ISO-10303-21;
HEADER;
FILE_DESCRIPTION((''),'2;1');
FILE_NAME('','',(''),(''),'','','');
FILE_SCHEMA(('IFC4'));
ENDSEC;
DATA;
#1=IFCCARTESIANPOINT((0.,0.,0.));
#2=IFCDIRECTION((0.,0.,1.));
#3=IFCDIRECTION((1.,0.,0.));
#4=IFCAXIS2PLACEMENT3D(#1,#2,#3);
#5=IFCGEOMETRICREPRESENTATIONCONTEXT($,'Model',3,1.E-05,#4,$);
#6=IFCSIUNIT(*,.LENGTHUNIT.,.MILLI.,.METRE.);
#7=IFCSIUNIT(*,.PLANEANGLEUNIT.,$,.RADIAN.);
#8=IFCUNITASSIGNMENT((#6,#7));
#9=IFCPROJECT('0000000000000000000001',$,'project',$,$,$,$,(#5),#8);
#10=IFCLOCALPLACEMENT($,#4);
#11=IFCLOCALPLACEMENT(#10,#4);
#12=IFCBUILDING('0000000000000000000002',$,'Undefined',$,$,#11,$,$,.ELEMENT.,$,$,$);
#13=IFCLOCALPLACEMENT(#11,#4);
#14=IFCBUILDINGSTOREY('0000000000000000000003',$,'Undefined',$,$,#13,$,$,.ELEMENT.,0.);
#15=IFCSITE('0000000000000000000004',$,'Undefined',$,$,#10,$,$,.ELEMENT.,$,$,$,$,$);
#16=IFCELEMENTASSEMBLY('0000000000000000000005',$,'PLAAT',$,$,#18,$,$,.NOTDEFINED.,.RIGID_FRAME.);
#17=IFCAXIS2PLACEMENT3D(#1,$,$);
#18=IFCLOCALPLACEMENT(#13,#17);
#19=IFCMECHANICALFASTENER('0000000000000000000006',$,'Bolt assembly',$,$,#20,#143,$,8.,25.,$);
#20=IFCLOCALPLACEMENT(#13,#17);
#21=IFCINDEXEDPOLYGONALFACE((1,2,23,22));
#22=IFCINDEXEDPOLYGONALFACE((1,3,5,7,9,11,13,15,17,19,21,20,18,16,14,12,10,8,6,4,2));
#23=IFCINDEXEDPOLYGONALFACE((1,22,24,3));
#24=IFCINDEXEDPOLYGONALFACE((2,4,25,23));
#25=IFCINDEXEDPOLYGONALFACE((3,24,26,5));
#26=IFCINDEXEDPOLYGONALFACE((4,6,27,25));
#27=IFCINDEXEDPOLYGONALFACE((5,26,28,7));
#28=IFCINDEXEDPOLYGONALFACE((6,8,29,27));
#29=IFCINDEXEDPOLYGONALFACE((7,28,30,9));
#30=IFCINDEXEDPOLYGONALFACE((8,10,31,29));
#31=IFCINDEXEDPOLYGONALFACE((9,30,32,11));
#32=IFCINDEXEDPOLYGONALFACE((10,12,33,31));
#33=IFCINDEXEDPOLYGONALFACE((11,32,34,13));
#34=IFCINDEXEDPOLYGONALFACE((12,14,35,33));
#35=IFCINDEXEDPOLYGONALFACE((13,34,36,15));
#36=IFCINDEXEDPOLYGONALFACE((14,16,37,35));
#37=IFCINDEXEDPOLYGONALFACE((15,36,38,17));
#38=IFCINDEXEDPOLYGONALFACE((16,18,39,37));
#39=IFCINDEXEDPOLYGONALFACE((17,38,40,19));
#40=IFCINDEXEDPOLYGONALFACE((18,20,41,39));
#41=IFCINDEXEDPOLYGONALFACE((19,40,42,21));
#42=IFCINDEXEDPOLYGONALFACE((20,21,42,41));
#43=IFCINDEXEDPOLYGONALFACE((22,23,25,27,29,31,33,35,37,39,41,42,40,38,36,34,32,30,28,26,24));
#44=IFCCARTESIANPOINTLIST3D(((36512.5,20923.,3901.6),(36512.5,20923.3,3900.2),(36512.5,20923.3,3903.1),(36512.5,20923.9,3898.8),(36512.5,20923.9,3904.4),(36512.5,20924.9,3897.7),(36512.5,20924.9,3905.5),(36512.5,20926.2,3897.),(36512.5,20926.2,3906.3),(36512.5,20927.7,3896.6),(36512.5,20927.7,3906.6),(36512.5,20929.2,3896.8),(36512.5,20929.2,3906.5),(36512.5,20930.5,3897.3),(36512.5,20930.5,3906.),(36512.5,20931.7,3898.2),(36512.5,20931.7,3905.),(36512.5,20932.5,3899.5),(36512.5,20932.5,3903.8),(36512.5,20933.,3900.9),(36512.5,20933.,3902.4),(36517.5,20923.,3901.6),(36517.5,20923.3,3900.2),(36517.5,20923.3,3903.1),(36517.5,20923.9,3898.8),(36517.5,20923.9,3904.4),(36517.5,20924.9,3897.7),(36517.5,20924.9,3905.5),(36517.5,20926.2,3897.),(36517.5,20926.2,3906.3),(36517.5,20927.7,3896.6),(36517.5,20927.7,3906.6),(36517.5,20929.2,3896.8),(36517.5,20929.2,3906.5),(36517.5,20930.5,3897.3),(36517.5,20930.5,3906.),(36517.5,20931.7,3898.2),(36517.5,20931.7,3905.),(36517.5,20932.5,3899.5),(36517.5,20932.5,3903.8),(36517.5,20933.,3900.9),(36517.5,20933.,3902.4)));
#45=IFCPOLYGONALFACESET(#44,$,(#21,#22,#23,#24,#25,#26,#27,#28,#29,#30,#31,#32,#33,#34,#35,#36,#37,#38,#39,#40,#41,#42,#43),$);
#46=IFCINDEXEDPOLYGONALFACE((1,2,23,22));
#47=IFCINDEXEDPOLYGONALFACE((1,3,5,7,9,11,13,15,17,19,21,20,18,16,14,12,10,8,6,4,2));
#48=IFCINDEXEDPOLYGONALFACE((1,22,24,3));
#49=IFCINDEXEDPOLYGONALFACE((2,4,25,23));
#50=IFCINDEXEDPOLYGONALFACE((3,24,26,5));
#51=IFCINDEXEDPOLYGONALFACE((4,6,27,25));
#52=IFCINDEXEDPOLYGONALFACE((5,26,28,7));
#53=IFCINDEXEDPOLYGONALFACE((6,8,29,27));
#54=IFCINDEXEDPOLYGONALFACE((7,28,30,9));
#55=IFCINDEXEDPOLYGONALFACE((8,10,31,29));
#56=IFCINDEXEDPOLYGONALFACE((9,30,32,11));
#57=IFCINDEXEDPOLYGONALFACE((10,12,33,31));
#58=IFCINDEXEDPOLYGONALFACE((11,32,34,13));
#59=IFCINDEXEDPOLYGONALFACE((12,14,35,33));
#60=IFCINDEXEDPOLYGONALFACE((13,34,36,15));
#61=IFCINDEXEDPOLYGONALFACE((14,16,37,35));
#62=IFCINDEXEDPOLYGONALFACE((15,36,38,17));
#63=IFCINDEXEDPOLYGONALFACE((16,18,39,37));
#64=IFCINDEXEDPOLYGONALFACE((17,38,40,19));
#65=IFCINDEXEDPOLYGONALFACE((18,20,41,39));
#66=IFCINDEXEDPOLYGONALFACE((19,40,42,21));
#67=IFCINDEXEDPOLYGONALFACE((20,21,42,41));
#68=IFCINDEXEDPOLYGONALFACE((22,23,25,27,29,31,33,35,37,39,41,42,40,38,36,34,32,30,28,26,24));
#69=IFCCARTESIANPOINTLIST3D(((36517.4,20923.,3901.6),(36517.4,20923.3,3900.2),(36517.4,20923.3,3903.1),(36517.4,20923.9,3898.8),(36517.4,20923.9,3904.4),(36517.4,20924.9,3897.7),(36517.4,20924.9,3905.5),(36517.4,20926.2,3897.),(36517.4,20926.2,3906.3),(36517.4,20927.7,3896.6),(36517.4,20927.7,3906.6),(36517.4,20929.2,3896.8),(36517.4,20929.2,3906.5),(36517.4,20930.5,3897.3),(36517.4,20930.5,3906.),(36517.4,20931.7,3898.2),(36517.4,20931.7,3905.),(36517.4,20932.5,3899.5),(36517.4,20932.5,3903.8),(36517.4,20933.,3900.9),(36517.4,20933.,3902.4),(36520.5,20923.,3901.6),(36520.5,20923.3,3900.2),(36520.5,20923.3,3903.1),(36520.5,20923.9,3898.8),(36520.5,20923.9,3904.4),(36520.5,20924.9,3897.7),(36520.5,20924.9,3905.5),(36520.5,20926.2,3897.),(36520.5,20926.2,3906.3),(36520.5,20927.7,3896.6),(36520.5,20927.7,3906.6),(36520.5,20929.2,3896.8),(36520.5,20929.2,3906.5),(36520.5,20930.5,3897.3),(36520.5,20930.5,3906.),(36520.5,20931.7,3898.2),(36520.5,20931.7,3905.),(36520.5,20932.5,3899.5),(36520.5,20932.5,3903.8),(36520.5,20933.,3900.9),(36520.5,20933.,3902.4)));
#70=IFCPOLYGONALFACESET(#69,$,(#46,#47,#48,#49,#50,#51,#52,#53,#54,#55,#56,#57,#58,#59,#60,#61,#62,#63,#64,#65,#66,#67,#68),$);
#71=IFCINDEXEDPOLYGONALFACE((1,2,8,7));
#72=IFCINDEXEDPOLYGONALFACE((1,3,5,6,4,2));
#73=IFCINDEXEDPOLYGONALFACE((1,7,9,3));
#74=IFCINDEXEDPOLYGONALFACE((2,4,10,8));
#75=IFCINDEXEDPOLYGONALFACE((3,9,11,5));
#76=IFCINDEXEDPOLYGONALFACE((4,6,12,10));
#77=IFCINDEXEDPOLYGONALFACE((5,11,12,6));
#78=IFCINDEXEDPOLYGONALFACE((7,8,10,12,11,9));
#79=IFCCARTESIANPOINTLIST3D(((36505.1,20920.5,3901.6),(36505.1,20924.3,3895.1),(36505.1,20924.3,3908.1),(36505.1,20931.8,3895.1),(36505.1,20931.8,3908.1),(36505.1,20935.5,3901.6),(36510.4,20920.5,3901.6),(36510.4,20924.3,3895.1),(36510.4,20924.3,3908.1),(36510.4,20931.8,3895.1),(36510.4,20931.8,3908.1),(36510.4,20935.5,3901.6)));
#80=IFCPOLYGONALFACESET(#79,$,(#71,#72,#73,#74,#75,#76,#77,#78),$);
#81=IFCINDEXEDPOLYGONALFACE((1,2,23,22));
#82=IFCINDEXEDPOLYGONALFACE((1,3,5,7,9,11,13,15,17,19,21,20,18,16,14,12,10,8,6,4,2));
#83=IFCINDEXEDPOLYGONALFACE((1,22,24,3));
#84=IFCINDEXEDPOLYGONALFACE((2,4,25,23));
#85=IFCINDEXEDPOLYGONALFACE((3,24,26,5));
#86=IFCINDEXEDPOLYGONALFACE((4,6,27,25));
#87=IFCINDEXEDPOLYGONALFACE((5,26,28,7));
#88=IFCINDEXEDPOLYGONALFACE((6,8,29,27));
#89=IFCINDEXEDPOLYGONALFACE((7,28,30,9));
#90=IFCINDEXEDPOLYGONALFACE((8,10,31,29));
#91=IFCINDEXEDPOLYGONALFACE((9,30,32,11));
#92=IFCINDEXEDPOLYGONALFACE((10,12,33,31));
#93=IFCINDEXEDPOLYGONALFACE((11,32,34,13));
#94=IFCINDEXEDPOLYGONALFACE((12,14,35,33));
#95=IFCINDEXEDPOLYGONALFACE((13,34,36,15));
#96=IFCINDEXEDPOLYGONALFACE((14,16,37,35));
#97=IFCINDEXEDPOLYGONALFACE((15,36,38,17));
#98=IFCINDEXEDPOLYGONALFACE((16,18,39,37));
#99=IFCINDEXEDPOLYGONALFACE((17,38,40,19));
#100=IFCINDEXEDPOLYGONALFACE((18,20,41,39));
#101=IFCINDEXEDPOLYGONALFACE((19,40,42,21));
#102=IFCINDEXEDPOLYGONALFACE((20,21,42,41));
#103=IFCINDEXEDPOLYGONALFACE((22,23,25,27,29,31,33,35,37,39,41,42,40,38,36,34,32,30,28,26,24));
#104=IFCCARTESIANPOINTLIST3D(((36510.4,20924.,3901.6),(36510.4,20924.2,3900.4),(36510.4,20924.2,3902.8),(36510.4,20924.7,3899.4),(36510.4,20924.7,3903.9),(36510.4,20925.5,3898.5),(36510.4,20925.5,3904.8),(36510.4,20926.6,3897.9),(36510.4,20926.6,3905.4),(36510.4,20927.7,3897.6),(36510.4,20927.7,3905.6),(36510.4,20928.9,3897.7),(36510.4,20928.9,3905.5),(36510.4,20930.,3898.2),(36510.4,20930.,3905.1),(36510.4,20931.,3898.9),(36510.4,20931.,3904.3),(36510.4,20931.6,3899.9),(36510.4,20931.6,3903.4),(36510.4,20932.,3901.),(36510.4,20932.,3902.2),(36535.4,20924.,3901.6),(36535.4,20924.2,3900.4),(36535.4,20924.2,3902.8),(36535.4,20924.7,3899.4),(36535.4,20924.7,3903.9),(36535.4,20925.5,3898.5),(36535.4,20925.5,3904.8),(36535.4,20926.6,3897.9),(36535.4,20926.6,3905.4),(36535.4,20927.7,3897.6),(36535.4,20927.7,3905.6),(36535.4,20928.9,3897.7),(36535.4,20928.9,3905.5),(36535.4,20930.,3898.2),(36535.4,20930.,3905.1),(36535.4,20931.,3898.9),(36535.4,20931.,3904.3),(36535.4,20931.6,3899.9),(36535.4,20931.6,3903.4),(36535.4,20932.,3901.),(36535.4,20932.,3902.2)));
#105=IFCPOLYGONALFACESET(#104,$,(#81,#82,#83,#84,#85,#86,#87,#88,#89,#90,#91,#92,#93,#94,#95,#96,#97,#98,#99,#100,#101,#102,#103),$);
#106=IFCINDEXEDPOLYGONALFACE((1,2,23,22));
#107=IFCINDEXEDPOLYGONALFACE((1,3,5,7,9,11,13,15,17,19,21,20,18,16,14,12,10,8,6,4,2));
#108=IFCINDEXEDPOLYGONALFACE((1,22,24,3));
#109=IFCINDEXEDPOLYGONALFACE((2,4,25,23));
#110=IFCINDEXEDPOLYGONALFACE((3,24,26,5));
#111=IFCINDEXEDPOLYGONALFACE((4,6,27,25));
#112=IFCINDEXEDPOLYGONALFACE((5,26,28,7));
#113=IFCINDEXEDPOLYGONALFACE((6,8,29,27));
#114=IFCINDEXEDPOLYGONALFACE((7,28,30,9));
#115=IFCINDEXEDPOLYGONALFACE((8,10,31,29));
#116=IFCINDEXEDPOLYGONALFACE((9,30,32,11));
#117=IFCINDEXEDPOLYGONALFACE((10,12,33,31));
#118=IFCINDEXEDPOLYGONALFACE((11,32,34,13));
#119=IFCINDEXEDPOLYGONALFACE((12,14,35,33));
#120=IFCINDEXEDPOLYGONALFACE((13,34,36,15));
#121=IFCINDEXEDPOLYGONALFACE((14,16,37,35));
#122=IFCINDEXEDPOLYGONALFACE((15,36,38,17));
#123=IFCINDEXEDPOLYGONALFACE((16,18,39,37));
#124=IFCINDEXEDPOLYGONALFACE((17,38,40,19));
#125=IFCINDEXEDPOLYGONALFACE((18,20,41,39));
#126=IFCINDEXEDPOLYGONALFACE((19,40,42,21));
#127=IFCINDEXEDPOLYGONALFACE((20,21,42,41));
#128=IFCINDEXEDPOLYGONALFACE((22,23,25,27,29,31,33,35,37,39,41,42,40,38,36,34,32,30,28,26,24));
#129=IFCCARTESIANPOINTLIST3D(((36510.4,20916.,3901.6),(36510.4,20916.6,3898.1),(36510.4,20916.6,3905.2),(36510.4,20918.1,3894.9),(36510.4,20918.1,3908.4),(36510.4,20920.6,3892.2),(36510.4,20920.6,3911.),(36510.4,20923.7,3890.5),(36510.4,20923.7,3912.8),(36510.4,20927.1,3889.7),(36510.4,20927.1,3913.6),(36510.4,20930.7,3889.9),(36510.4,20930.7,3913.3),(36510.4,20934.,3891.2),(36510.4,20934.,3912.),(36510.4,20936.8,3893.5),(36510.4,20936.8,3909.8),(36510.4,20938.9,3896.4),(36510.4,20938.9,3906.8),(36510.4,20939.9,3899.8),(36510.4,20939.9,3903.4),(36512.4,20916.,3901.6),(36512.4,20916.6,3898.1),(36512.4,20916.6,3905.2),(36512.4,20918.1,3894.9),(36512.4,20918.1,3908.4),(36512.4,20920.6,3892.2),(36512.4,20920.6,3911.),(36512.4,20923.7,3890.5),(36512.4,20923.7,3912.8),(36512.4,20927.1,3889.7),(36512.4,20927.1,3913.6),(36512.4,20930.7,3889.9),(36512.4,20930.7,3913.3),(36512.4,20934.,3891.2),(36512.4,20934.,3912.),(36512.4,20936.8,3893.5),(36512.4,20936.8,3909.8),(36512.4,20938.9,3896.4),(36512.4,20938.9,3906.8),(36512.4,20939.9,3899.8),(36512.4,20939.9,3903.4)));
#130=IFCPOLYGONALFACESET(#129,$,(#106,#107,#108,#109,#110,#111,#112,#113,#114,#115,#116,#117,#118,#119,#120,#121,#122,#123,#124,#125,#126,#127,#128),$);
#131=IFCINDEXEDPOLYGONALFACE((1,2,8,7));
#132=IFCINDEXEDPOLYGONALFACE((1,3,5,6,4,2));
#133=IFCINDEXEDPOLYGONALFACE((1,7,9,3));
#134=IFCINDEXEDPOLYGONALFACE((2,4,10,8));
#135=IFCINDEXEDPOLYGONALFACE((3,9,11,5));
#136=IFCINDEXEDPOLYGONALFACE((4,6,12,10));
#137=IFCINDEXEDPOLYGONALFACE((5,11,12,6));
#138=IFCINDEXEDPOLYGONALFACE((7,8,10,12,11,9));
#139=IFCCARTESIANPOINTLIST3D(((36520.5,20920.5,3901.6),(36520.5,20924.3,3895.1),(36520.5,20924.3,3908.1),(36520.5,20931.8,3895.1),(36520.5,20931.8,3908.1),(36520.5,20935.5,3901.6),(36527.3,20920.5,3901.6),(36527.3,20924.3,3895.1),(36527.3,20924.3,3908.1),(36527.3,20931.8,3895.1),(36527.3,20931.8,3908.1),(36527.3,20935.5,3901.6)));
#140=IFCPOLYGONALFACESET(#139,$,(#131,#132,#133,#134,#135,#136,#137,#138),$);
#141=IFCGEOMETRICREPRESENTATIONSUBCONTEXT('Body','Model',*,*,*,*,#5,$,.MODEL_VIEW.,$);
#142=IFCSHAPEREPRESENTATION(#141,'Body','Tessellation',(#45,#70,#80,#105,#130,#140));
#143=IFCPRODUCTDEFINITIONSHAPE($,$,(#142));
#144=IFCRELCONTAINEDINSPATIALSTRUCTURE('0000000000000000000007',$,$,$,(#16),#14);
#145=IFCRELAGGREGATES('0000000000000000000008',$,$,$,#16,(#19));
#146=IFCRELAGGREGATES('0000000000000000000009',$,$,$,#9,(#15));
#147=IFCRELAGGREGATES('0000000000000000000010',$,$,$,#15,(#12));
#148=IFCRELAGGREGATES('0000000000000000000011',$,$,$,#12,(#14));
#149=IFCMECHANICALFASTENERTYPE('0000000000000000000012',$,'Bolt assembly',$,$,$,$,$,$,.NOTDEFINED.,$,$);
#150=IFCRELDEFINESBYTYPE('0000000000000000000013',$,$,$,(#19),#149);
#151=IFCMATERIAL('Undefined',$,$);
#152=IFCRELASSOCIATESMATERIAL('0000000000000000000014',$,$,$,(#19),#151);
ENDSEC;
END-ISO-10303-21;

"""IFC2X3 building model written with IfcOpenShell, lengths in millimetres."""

from ifc_helpers import new_model, si_unit, frame, origin_with_axes, origin_2d_with_axis, place, context, subcontext, project, spatial, polyline, circle, outline, extrude, source, transform, mapped, material, type_object, element, aggregate, save


model = new_model("IFC2X3")

# Units and contexts
model_context = context("Model", 3, precision=1e-05, world=origin_with_axes())
body_context = subcontext(model_context, "Body", "Model", "MODEL_VIEW")
ifc_project = project(units=[si_unit("LENGTHUNIT", "METRE", prefix="MILLI"), si_unit("PLANEANGLEUNIT", "RADIAN")], contexts=[model_context])

# Site, building, storey
site_placement = place(None, origin_with_axes())
site = spatial("IfcSite", under=ifc_project, at=site_placement, Name="Undefined", CompositionType="ELEMENT")
building_placement = place(site_placement, origin_with_axes())
building = spatial("IfcBuilding", under=site, at=building_placement, Name="Undefined", CompositionType="ELEMENT")
storey_placement = place(building_placement, origin_with_axes())
storey = spatial("IfcBuildingStorey", under=building, at=storey_placement, Name="Undefined", CompositionType="ELEMENT", Elevation=0.0)

# Shared definitions
ifc_material_1 = material(Name="Undefined")
mechanical_fastener_type = type_object("IfcMechanicalFastenerType", Name="Bolt assembly")
shared_shape_1 = source(origin_with_axes(), body_context, "Body", "SweptSolid", [
    extrude(circle(Radius=5.0, at=origin_2d_with_axis()), frame((0.0, 7.5, 0.0), z_axis=(0.0, 1.0, 0.0), x_axis=(1.0, 0.0, 0.0)), (0.0, 0.0, 1.0), 5.0),
    extrude(circle(Radius=5.0, at=origin_2d_with_axis()), frame((0.0, 12.4, 0.0), z_axis=(0.0, 1.0, 0.0), x_axis=(1.0, 0.0, 0.0)), (0.0, 0.0, 1.0), 3.1),
    extrude(outline(polyline([(7.5, 0.0), (3.8, 6.5), (-3.8, 6.5), (-7.5, 0.0), (-3.8, -6.5), (3.8, -6.5), (7.5, 0.0)])), frame((0.0, 0.1, 0.0), z_axis=(0.0, 1.0, 0.0), x_axis=(1.0, 0.0, 0.0)), (0.0, 0.0, 1.0), 5.3),
    extrude(circle(Radius=4.0, at=origin_2d_with_axis()), frame((0.0, 5.4, 0.0), z_axis=(0.0, 1.0, 0.0), x_axis=(1.0, 0.0, 0.0)), (0.0, 0.0, 1.0), 25.0),
    extrude(circle(Radius=12.0, at=origin_2d_with_axis()), frame((0.0, 5.4, 0.0), z_axis=(0.0, 1.0, 0.0), x_axis=(1.0, 0.0, 0.0)), (0.0, 0.0, 1.0), 2.0),
    extrude(outline(polyline([(7.5, 0.0), (3.8, 6.5), (-3.8, 6.5), (-7.5, 0.0), (-3.8, -6.5), (3.8, -6.5), (7.5, 0.0)])), frame((0.0, 15.5, 0.0), z_axis=(0.0, 1.0, 0.0), x_axis=(1.0, 0.0, 0.0)), (0.0, 0.0, 1.0), 6.8),
])

# Element assembly, mechanical fastener
assembly_1_placement = place(storey_placement, origin_with_axes())
assembly_1 = element("IfcElementAssembly", 1, at=assembly_1_placement, inside=storey, Name="PLAAT", AssemblyPlace="NOTDEFINED", PredefinedType="RIGID_FRAME")
mechanical_fastener_1_placement = place(assembly_1_placement, frame((36505.0, 20928.0, 3901.6), z_axis=(0.0, 0.000002, 1.0), x_axis=(0.0, -1.0, 0.000002)))
mechanical_fastener_1 = element("IfcMechanicalFastener", 2, at=mechanical_fastener_1_placement, type_object=mechanical_fastener_type, material=ifc_material_1, Name="Bolt assembly", NominalDiameter=8.0, NominalLength=25.0, context=body_context, shape_type="MappedRepresentation", body=[
    mapped(shared_shape_1, transform((0.0, 0.0, 0.0))),
])
aggregate(assembly_1, [mechanical_fastener_1])

save(model, "model.ifc")
